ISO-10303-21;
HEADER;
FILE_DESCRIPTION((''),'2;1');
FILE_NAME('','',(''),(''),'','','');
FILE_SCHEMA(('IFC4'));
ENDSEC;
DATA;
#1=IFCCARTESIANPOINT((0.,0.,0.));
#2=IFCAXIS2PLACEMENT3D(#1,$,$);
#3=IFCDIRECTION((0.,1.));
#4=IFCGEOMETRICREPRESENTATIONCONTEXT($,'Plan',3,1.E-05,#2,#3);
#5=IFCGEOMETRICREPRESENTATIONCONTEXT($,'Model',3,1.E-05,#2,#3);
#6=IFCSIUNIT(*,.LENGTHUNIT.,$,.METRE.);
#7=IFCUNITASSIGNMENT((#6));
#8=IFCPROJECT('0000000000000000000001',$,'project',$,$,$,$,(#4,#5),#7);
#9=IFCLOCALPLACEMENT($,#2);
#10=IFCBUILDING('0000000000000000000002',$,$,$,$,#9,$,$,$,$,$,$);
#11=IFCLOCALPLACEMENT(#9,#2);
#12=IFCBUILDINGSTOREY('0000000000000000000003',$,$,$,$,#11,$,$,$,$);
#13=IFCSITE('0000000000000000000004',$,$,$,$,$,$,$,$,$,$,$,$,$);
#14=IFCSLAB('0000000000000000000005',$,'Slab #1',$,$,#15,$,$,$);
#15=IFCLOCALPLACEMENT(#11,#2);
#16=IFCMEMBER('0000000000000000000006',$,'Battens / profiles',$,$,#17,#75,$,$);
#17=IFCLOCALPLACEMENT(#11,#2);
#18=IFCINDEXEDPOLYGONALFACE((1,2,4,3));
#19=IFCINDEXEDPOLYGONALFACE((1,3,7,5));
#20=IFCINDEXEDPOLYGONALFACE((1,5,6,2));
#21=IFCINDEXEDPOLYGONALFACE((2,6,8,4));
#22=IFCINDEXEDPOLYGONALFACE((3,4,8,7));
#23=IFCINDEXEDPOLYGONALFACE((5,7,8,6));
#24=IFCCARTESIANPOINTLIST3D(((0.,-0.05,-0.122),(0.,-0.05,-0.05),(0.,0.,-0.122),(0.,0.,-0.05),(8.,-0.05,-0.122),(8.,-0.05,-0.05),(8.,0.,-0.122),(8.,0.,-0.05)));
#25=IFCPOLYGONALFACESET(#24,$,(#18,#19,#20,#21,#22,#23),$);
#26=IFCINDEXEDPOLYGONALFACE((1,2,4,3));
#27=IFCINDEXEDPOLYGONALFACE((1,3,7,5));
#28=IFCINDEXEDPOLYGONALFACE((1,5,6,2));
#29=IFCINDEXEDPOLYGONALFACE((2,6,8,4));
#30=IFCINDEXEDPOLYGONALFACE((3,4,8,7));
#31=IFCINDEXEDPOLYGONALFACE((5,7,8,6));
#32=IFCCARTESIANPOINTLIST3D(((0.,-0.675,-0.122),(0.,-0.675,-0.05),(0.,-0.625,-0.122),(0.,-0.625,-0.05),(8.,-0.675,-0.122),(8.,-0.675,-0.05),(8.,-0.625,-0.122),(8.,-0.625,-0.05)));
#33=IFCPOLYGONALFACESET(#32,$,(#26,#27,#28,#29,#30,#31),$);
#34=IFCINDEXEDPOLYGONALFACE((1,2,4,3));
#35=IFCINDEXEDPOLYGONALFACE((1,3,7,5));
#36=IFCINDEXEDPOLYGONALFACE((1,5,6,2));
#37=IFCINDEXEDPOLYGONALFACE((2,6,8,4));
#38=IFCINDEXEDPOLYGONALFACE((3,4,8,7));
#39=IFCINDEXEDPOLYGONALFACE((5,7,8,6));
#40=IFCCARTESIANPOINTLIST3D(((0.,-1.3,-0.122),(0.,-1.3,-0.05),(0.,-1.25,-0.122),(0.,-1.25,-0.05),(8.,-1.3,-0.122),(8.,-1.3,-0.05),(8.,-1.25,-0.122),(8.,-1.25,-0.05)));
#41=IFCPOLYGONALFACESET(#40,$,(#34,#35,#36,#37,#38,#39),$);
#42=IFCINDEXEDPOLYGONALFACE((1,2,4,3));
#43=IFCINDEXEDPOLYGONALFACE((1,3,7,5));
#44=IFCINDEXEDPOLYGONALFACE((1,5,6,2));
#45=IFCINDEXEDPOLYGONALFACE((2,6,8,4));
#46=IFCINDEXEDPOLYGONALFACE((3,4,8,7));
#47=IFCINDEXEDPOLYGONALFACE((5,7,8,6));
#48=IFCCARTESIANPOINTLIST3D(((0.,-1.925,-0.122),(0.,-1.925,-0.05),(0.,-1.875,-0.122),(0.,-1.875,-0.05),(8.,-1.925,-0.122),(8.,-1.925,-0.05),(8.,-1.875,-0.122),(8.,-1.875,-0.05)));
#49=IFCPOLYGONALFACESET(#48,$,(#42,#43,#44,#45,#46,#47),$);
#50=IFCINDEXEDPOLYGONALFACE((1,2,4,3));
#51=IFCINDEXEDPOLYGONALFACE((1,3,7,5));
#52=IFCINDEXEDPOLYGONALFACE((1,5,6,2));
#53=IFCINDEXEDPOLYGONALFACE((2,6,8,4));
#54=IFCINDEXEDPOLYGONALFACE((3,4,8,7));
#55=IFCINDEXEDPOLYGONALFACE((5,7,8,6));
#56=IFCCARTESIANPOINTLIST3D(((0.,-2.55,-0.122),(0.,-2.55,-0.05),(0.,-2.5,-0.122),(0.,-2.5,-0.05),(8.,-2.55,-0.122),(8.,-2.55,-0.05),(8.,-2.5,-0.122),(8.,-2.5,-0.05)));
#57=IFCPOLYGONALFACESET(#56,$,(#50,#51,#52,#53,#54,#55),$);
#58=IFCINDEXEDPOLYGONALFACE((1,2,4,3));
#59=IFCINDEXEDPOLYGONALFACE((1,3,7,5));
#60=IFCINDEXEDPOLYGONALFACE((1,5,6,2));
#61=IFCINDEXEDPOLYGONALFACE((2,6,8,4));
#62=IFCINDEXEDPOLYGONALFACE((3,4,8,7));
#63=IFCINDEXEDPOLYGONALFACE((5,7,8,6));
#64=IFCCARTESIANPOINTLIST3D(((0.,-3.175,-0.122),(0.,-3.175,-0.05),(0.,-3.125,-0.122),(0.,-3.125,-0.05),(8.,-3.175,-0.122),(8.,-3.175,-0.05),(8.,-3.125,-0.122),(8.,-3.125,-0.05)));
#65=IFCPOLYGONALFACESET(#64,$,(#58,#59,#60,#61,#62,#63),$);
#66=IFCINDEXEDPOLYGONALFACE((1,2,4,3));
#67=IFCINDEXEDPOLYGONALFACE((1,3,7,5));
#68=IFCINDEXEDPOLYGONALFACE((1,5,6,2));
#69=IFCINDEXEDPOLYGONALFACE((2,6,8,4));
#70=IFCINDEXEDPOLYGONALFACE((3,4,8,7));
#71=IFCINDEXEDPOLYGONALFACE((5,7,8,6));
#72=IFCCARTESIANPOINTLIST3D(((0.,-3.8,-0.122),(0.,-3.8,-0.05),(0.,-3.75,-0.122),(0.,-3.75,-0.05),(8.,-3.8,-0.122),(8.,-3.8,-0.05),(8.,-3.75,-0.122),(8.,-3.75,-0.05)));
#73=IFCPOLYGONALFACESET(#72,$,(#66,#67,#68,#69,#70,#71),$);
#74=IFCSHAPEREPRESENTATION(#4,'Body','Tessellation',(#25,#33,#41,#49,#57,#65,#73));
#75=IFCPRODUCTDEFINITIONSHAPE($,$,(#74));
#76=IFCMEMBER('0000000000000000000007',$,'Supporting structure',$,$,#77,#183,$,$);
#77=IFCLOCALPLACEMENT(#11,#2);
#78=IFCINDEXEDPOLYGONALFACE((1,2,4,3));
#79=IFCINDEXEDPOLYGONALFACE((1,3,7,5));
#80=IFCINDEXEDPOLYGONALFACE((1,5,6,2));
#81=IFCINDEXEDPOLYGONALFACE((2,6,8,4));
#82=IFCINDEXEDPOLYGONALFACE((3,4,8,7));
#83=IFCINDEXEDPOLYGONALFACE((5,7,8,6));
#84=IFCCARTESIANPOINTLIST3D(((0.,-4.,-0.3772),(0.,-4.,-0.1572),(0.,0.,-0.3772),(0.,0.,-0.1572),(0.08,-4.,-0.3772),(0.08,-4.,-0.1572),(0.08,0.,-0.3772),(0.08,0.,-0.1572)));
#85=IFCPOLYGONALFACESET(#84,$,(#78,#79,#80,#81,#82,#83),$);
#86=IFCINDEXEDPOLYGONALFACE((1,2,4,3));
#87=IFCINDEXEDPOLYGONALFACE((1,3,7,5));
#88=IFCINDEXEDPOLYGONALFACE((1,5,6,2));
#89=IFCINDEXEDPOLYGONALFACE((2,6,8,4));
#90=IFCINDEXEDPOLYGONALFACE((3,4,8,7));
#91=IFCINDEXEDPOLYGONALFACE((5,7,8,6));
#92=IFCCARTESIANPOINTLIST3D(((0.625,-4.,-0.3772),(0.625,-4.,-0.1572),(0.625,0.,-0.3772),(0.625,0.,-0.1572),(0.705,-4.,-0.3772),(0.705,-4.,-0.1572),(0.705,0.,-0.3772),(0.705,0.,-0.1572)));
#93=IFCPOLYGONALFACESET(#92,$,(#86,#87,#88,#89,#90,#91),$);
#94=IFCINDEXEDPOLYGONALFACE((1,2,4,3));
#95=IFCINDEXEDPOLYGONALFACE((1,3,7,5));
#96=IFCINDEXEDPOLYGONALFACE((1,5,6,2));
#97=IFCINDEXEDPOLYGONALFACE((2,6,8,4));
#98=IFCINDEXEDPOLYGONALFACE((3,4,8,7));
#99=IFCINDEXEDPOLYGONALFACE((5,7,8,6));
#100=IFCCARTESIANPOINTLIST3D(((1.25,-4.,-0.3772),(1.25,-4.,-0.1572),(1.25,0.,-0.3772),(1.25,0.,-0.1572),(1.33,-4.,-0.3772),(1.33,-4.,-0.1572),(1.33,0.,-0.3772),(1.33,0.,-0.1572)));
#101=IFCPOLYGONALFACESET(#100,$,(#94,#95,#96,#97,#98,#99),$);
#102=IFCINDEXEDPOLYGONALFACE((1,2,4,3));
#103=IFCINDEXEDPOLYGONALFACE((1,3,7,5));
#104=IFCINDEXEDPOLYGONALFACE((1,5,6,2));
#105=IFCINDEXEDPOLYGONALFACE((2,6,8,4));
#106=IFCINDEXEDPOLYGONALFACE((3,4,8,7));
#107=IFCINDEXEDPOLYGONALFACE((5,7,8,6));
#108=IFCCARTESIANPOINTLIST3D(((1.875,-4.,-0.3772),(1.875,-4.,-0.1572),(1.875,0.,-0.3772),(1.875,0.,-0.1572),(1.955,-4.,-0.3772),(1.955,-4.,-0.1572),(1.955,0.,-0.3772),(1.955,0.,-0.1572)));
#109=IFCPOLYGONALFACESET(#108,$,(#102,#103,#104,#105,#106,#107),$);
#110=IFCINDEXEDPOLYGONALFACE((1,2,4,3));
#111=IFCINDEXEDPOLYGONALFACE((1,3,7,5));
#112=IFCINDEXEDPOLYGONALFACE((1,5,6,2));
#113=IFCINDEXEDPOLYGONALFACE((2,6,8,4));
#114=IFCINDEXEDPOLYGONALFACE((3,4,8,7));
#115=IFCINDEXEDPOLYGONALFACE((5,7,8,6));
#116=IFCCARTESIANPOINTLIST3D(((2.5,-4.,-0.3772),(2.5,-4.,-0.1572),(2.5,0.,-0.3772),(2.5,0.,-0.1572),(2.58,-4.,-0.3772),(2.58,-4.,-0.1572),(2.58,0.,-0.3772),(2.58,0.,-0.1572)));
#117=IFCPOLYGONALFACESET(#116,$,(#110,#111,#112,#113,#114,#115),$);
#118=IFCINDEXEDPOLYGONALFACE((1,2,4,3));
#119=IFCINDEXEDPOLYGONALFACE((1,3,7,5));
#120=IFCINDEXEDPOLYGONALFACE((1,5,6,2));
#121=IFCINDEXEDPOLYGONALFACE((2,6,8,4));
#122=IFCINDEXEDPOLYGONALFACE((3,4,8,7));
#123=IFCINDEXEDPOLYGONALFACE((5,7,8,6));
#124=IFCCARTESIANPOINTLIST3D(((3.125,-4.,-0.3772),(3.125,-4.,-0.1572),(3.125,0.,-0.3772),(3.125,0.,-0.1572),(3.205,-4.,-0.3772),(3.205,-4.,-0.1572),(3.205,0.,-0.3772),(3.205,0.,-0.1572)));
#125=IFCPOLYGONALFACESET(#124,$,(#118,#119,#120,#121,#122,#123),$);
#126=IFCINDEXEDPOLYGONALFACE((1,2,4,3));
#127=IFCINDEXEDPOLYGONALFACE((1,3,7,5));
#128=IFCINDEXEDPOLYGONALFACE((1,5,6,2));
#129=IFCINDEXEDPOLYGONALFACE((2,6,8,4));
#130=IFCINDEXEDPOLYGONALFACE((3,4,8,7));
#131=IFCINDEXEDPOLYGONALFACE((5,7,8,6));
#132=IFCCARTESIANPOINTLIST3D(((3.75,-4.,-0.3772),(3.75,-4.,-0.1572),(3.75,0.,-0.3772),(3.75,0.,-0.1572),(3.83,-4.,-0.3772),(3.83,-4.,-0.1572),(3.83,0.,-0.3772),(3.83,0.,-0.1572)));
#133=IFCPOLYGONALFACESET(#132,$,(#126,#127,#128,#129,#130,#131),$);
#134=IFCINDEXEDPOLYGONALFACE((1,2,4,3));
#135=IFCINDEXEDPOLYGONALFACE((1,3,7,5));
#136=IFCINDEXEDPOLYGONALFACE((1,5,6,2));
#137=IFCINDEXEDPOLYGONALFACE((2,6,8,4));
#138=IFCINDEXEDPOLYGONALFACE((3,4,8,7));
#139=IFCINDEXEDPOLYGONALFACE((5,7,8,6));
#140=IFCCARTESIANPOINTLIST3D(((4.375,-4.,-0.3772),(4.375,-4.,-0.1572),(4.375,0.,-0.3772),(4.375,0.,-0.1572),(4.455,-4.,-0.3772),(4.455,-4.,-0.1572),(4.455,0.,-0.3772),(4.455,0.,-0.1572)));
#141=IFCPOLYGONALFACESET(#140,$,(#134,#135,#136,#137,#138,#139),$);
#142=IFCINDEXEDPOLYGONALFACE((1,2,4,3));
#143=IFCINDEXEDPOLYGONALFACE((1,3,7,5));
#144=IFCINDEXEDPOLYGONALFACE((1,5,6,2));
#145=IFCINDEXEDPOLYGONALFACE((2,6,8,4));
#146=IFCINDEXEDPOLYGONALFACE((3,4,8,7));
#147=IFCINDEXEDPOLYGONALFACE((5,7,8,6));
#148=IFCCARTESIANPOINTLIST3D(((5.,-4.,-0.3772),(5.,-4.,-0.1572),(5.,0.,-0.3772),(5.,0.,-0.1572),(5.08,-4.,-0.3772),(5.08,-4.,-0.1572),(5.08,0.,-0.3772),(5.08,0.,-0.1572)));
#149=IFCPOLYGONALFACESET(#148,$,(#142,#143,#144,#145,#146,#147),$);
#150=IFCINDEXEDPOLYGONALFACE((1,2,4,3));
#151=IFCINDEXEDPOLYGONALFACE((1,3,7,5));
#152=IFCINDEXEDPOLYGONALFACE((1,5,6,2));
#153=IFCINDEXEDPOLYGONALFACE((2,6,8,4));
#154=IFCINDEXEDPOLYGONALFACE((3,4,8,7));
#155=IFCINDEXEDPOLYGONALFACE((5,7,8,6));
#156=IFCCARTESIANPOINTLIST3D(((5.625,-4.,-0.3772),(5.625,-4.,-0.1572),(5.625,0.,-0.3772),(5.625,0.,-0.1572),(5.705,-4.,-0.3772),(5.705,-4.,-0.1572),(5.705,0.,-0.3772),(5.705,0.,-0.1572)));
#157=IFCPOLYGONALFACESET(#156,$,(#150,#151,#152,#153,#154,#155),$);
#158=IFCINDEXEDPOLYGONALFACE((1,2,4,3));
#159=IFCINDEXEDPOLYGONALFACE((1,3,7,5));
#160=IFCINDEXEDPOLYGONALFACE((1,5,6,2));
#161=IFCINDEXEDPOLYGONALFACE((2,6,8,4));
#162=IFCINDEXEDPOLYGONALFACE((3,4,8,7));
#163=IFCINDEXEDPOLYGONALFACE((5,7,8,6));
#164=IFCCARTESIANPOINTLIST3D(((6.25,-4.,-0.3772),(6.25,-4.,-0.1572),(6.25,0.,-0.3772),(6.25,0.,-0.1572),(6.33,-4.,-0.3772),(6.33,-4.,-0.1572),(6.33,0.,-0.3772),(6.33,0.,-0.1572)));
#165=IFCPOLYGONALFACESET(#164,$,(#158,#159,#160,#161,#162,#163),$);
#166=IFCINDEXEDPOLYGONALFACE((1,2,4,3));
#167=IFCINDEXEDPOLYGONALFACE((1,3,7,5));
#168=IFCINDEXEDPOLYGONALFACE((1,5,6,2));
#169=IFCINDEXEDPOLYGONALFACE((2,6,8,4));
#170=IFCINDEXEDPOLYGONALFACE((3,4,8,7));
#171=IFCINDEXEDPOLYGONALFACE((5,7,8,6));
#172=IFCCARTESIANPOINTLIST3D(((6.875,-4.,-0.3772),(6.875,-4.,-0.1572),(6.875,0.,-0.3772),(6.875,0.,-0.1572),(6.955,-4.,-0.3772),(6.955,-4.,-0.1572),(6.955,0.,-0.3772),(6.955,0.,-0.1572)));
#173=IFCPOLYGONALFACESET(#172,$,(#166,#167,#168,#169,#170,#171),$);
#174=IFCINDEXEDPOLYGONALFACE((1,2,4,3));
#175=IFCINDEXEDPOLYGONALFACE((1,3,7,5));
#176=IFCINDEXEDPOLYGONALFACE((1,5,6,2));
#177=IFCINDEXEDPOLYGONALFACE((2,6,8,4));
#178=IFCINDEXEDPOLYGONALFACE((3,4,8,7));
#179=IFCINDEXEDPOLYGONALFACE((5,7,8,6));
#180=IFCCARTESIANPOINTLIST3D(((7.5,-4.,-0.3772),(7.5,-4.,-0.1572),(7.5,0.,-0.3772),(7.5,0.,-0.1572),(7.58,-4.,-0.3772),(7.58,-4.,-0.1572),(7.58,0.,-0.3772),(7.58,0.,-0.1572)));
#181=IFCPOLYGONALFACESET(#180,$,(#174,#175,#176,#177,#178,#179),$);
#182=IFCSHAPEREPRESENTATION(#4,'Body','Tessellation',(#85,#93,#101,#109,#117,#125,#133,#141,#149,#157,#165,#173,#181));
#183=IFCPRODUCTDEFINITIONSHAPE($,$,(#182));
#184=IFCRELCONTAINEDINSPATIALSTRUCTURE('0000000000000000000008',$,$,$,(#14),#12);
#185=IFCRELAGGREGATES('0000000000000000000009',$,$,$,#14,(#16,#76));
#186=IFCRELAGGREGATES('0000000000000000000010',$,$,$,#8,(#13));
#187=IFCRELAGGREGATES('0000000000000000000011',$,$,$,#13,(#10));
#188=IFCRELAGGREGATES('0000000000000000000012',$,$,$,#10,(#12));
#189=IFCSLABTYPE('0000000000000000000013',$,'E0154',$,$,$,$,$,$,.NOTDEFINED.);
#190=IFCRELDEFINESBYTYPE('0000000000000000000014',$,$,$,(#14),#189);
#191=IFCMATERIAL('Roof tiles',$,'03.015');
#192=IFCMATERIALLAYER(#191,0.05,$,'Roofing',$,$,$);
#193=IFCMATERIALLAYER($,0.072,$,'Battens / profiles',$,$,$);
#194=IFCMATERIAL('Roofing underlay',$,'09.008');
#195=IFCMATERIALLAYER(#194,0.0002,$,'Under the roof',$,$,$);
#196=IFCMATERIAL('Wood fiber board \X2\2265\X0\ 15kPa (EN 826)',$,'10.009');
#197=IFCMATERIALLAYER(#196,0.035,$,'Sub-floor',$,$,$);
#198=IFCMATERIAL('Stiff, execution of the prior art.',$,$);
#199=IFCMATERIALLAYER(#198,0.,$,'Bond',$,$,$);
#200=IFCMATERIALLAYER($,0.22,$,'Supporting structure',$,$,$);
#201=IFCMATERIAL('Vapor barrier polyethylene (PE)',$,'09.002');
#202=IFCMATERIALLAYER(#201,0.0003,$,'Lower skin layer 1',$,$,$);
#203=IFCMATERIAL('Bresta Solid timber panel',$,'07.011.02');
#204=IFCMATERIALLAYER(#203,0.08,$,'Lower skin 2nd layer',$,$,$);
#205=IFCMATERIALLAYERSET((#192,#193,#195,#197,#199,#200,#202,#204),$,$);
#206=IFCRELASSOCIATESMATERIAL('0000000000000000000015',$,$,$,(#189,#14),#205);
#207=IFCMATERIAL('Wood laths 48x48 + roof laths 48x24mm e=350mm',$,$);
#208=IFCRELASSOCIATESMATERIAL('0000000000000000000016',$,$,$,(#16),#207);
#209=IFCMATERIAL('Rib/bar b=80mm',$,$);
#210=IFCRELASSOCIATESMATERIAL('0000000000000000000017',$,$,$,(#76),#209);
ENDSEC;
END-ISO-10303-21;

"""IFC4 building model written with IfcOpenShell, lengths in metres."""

from ifc_helpers import new_model, si_unit, direction, frame, frame_2d, origin, place, context, project, spatial, rectangle, extrude, material, layer, layer_set, type_object, element, aggregate, save


model = new_model("IFC4")

# Units and contexts
plan_context = context("Plan", 3, precision=1e-05, world=origin(), true_north=direction((0.0, 1.0)))
model_context = context("Model", 3, precision=1e-05, world=origin(), true_north=direction((0.0, 1.0)))
ifc_project = project(units=[si_unit("LENGTHUNIT", "METRE")], contexts=[plan_context, model_context])

# Site, building, storey
site = spatial("IfcSite", under=ifc_project)
building_placement = place(None, origin())
building = spatial("IfcBuilding", under=site, at=building_placement)
storey_placement = place(building_placement, origin())
storey = spatial("IfcBuildingStorey", under=building, at=storey_placement)

# Slab, members
ifc_material_1 = material(Name="Roof tiles", Category="03.015")
ifc_layer_1 = layer(ifc_material_1, 0.05, Name="Roofing")
ifc_layer_2 = layer(None, 0.072, Name="Battens / profiles")
ifc_material_2 = material(Name="Roofing underlay", Category="09.008")
ifc_layer_3 = layer(ifc_material_2, 0.0002, Name="Under the roof")
ifc_material_3 = material(Name="Wood fiber board ≥ 15kPa (EN 826)", Category="10.009")
ifc_layer_4 = layer(ifc_material_3, 0.035, Name="Sub-floor")
ifc_material_4 = material(Name="Stiff, execution of the prior art.")
ifc_layer_5 = layer(ifc_material_4, 0.0, Name="Bond")
ifc_layer_6 = layer(None, 0.22, Name="Supporting structure")
ifc_material_5 = material(Name="Vapor barrier polyethylene (PE)", Category="09.002")
ifc_layer_7 = layer(ifc_material_5, 0.0003, Name="Lower skin layer 1")
ifc_material_6 = material(Name="Bresta Solid timber panel", Category="07.011.02")
ifc_layer_8 = layer(ifc_material_6, 0.08, Name="Lower skin 2nd layer")
ifc_layer_set = layer_set([ifc_layer_1, ifc_layer_2, ifc_layer_3, ifc_layer_4, ifc_layer_5, ifc_layer_6, ifc_layer_7, ifc_layer_8])
slab_type = type_object("IfcSlabType", Name="E0154", PredefinedType="NOTDEFINED", material=ifc_layer_set)
slab_placement = place(None, frame((0.0, 0.0, 0.0), z_axis=(0.0, 0.0, -1.0), x_axis=(1.0, 0.0, 0.0)))
slab = element("IfcSlab", 1, at=slab_placement, inside=storey, type_object=slab_type, material=ifc_layer_set, Name="Slab #1")
ifc_material_7 = material(Name="Wood laths 48x48 + roof laths 48x24mm e=350mm")
member_1_placement = place(slab_placement, origin())
member_1 = element("IfcMember", 2, at=member_1_placement, material=ifc_material_7, Name="Battens / profiles", context=plan_context, shape_type="SweptSolid", body=[
    extrude(rectangle(XDim=0.05, YDim=0.072, at=frame_2d((0.025, 0.036), x_axis=(1.0, 0.0))), frame((0.0, 0.0, 0.05), z_axis=(1.0, 0.0, 0.0), x_axis=(0.0, 1.0, 0.0)), (0.0, 0.0, 1.0), 8.0),
    extrude(rectangle(XDim=0.05, YDim=0.072, at=frame_2d((0.025, 0.036), x_axis=(1.0, 0.0))), frame((0.0, 0.625, 0.05), z_axis=(1.0, 0.0, 0.0), x_axis=(0.0, 1.0, 0.0)), (0.0, 0.0, 1.0), 8.0),
    extrude(rectangle(XDim=0.05, YDim=0.072, at=frame_2d((0.025, 0.036), x_axis=(1.0, 0.0))), frame((0.0, 1.25, 0.05), z_axis=(1.0, 0.0, 0.0), x_axis=(0.0, 1.0, 0.0)), (0.0, 0.0, 1.0), 8.0),
    extrude(rectangle(XDim=0.05, YDim=0.072, at=frame_2d((0.025, 0.036), x_axis=(1.0, 0.0))), frame((0.0, 1.875, 0.05), z_axis=(1.0, 0.0, 0.0), x_axis=(0.0, 1.0, 0.0)), (0.0, 0.0, 1.0), 8.0),
    extrude(rectangle(XDim=0.05, YDim=0.072, at=frame_2d((0.025, 0.036), x_axis=(1.0, 0.0))), frame((0.0, 2.5, 0.05), z_axis=(1.0, 0.0, 0.0), x_axis=(0.0, 1.0, 0.0)), (0.0, 0.0, 1.0), 8.0),
    extrude(rectangle(XDim=0.05, YDim=0.072, at=frame_2d((0.025, 0.036), x_axis=(1.0, 0.0))), frame((0.0, 3.125, 0.05), z_axis=(1.0, 0.0, 0.0), x_axis=(0.0, 1.0, 0.0)), (0.0, 0.0, 1.0), 8.0),
    extrude(rectangle(XDim=0.05, YDim=0.072, at=frame_2d((0.025, 0.036), x_axis=(1.0, 0.0))), frame((0.0, 3.75, 0.05), z_axis=(1.0, 0.0, 0.0), x_axis=(0.0, 1.0, 0.0)), (0.0, 0.0, 1.0), 8.0),
])
ifc_material_8 = material(Name="Rib/bar b=80mm")
member_2_placement = place(slab_placement, origin())
member_2 = element("IfcMember", 3, at=member_2_placement, material=ifc_material_8, Name="Supporting structure", context=plan_context, shape_type="SweptSolid", body=[
    extrude(rectangle(XDim=0.08, YDim=0.22, at=frame_2d((0.04, 0.11), x_axis=(1.0, 0.0))), frame((0.0, 4.0, 0.1572), z_axis=(0.0, -1.0, 0.0), x_axis=(1.0, 0.0, 0.0)), (0.0, 0.0, 1.0), 4.0),
    extrude(rectangle(XDim=0.08, YDim=0.22, at=frame_2d((0.04, 0.11), x_axis=(1.0, 0.0))), frame((0.625, 4.0, 0.1572), z_axis=(0.0, -1.0, 0.0), x_axis=(1.0, 0.0, 0.0)), (0.0, 0.0, 1.0), 4.0),
    extrude(rectangle(XDim=0.08, YDim=0.22, at=frame_2d((0.04, 0.11), x_axis=(1.0, 0.0))), frame((1.25, 4.0, 0.1572), z_axis=(0.0, -1.0, 0.0), x_axis=(1.0, 0.0, 0.0)), (0.0, 0.0, 1.0), 4.0),
    extrude(rectangle(XDim=0.08, YDim=0.22, at=frame_2d((0.04, 0.11), x_axis=(1.0, 0.0))), frame((1.875, 4.0, 0.1572), z_axis=(0.0, -1.0, 0.0), x_axis=(1.0, 0.0, 0.0)), (0.0, 0.0, 1.0), 4.0),
    extrude(rectangle(XDim=0.08, YDim=0.22, at=frame_2d((0.04, 0.11), x_axis=(1.0, 0.0))), frame((2.5, 4.0, 0.1572), z_axis=(0.0, -1.0, 0.0), x_axis=(1.0, 0.0, 0.0)), (0.0, 0.0, 1.0), 4.0),
    extrude(rectangle(XDim=0.08, YDim=0.22, at=frame_2d((0.04, 0.11), x_axis=(1.0, 0.0))), frame((3.125, 4.0, 0.1572), z_axis=(0.0, -1.0, 0.0), x_axis=(1.0, 0.0, 0.0)), (0.0, 0.0, 1.0), 4.0),
    extrude(rectangle(XDim=0.08, YDim=0.22, at=frame_2d((0.04, 0.11), x_axis=(1.0, 0.0))), frame((3.75, 4.0, 0.1572), z_axis=(0.0, -1.0, 0.0), x_axis=(1.0, 0.0, 0.0)), (0.0, 0.0, 1.0), 4.0),
    extrude(rectangle(XDim=0.08, YDim=0.22, at=frame_2d((0.04, 0.11), x_axis=(1.0, 0.0))), frame((4.375, 4.0, 0.1572), z_axis=(0.0, -1.0, 0.0), x_axis=(1.0, 0.0, 0.0)), (0.0, 0.0, 1.0), 4.0),
    extrude(rectangle(XDim=0.08, YDim=0.22, at=frame_2d((0.04, 0.11), x_axis=(1.0, 0.0))), frame((5.0, 4.0, 0.1572), z_axis=(0.0, -1.0, 0.0), x_axis=(1.0, 0.0, 0.0)), (0.0, 0.0, 1.0), 4.0),
    extrude(rectangle(XDim=0.08, YDim=0.22, at=frame_2d((0.04, 0.11), x_axis=(1.0, 0.0))), frame((5.625, 4.0, 0.1572), z_axis=(0.0, -1.0, 0.0), x_axis=(1.0, 0.0, 0.0)), (0.0, 0.0, 1.0), 4.0),
    extrude(rectangle(XDim=0.08, YDim=0.22, at=frame_2d((0.04, 0.11), x_axis=(1.0, 0.0))), frame((6.25, 4.0, 0.1572), z_axis=(0.0, -1.0, 0.0), x_axis=(1.0, 0.0, 0.0)), (0.0, 0.0, 1.0), 4.0),
    extrude(rectangle(XDim=0.08, YDim=0.22, at=frame_2d((0.04, 0.11), x_axis=(1.0, 0.0))), frame((6.875, 4.0, 0.1572), z_axis=(0.0, -1.0, 0.0), x_axis=(1.0, 0.0, 0.0)), (0.0, 0.0, 1.0), 4.0),
    extrude(rectangle(XDim=0.08, YDim=0.22, at=frame_2d((0.04, 0.11), x_axis=(1.0, 0.0))), frame((7.5, 4.0, 0.1572), z_axis=(0.0, -1.0, 0.0), x_axis=(1.0, 0.0, 0.0)), (0.0, 0.0, 1.0), 4.0),
])
aggregate(slab, [member_1, member_2])

save(model, "model.ifc")
